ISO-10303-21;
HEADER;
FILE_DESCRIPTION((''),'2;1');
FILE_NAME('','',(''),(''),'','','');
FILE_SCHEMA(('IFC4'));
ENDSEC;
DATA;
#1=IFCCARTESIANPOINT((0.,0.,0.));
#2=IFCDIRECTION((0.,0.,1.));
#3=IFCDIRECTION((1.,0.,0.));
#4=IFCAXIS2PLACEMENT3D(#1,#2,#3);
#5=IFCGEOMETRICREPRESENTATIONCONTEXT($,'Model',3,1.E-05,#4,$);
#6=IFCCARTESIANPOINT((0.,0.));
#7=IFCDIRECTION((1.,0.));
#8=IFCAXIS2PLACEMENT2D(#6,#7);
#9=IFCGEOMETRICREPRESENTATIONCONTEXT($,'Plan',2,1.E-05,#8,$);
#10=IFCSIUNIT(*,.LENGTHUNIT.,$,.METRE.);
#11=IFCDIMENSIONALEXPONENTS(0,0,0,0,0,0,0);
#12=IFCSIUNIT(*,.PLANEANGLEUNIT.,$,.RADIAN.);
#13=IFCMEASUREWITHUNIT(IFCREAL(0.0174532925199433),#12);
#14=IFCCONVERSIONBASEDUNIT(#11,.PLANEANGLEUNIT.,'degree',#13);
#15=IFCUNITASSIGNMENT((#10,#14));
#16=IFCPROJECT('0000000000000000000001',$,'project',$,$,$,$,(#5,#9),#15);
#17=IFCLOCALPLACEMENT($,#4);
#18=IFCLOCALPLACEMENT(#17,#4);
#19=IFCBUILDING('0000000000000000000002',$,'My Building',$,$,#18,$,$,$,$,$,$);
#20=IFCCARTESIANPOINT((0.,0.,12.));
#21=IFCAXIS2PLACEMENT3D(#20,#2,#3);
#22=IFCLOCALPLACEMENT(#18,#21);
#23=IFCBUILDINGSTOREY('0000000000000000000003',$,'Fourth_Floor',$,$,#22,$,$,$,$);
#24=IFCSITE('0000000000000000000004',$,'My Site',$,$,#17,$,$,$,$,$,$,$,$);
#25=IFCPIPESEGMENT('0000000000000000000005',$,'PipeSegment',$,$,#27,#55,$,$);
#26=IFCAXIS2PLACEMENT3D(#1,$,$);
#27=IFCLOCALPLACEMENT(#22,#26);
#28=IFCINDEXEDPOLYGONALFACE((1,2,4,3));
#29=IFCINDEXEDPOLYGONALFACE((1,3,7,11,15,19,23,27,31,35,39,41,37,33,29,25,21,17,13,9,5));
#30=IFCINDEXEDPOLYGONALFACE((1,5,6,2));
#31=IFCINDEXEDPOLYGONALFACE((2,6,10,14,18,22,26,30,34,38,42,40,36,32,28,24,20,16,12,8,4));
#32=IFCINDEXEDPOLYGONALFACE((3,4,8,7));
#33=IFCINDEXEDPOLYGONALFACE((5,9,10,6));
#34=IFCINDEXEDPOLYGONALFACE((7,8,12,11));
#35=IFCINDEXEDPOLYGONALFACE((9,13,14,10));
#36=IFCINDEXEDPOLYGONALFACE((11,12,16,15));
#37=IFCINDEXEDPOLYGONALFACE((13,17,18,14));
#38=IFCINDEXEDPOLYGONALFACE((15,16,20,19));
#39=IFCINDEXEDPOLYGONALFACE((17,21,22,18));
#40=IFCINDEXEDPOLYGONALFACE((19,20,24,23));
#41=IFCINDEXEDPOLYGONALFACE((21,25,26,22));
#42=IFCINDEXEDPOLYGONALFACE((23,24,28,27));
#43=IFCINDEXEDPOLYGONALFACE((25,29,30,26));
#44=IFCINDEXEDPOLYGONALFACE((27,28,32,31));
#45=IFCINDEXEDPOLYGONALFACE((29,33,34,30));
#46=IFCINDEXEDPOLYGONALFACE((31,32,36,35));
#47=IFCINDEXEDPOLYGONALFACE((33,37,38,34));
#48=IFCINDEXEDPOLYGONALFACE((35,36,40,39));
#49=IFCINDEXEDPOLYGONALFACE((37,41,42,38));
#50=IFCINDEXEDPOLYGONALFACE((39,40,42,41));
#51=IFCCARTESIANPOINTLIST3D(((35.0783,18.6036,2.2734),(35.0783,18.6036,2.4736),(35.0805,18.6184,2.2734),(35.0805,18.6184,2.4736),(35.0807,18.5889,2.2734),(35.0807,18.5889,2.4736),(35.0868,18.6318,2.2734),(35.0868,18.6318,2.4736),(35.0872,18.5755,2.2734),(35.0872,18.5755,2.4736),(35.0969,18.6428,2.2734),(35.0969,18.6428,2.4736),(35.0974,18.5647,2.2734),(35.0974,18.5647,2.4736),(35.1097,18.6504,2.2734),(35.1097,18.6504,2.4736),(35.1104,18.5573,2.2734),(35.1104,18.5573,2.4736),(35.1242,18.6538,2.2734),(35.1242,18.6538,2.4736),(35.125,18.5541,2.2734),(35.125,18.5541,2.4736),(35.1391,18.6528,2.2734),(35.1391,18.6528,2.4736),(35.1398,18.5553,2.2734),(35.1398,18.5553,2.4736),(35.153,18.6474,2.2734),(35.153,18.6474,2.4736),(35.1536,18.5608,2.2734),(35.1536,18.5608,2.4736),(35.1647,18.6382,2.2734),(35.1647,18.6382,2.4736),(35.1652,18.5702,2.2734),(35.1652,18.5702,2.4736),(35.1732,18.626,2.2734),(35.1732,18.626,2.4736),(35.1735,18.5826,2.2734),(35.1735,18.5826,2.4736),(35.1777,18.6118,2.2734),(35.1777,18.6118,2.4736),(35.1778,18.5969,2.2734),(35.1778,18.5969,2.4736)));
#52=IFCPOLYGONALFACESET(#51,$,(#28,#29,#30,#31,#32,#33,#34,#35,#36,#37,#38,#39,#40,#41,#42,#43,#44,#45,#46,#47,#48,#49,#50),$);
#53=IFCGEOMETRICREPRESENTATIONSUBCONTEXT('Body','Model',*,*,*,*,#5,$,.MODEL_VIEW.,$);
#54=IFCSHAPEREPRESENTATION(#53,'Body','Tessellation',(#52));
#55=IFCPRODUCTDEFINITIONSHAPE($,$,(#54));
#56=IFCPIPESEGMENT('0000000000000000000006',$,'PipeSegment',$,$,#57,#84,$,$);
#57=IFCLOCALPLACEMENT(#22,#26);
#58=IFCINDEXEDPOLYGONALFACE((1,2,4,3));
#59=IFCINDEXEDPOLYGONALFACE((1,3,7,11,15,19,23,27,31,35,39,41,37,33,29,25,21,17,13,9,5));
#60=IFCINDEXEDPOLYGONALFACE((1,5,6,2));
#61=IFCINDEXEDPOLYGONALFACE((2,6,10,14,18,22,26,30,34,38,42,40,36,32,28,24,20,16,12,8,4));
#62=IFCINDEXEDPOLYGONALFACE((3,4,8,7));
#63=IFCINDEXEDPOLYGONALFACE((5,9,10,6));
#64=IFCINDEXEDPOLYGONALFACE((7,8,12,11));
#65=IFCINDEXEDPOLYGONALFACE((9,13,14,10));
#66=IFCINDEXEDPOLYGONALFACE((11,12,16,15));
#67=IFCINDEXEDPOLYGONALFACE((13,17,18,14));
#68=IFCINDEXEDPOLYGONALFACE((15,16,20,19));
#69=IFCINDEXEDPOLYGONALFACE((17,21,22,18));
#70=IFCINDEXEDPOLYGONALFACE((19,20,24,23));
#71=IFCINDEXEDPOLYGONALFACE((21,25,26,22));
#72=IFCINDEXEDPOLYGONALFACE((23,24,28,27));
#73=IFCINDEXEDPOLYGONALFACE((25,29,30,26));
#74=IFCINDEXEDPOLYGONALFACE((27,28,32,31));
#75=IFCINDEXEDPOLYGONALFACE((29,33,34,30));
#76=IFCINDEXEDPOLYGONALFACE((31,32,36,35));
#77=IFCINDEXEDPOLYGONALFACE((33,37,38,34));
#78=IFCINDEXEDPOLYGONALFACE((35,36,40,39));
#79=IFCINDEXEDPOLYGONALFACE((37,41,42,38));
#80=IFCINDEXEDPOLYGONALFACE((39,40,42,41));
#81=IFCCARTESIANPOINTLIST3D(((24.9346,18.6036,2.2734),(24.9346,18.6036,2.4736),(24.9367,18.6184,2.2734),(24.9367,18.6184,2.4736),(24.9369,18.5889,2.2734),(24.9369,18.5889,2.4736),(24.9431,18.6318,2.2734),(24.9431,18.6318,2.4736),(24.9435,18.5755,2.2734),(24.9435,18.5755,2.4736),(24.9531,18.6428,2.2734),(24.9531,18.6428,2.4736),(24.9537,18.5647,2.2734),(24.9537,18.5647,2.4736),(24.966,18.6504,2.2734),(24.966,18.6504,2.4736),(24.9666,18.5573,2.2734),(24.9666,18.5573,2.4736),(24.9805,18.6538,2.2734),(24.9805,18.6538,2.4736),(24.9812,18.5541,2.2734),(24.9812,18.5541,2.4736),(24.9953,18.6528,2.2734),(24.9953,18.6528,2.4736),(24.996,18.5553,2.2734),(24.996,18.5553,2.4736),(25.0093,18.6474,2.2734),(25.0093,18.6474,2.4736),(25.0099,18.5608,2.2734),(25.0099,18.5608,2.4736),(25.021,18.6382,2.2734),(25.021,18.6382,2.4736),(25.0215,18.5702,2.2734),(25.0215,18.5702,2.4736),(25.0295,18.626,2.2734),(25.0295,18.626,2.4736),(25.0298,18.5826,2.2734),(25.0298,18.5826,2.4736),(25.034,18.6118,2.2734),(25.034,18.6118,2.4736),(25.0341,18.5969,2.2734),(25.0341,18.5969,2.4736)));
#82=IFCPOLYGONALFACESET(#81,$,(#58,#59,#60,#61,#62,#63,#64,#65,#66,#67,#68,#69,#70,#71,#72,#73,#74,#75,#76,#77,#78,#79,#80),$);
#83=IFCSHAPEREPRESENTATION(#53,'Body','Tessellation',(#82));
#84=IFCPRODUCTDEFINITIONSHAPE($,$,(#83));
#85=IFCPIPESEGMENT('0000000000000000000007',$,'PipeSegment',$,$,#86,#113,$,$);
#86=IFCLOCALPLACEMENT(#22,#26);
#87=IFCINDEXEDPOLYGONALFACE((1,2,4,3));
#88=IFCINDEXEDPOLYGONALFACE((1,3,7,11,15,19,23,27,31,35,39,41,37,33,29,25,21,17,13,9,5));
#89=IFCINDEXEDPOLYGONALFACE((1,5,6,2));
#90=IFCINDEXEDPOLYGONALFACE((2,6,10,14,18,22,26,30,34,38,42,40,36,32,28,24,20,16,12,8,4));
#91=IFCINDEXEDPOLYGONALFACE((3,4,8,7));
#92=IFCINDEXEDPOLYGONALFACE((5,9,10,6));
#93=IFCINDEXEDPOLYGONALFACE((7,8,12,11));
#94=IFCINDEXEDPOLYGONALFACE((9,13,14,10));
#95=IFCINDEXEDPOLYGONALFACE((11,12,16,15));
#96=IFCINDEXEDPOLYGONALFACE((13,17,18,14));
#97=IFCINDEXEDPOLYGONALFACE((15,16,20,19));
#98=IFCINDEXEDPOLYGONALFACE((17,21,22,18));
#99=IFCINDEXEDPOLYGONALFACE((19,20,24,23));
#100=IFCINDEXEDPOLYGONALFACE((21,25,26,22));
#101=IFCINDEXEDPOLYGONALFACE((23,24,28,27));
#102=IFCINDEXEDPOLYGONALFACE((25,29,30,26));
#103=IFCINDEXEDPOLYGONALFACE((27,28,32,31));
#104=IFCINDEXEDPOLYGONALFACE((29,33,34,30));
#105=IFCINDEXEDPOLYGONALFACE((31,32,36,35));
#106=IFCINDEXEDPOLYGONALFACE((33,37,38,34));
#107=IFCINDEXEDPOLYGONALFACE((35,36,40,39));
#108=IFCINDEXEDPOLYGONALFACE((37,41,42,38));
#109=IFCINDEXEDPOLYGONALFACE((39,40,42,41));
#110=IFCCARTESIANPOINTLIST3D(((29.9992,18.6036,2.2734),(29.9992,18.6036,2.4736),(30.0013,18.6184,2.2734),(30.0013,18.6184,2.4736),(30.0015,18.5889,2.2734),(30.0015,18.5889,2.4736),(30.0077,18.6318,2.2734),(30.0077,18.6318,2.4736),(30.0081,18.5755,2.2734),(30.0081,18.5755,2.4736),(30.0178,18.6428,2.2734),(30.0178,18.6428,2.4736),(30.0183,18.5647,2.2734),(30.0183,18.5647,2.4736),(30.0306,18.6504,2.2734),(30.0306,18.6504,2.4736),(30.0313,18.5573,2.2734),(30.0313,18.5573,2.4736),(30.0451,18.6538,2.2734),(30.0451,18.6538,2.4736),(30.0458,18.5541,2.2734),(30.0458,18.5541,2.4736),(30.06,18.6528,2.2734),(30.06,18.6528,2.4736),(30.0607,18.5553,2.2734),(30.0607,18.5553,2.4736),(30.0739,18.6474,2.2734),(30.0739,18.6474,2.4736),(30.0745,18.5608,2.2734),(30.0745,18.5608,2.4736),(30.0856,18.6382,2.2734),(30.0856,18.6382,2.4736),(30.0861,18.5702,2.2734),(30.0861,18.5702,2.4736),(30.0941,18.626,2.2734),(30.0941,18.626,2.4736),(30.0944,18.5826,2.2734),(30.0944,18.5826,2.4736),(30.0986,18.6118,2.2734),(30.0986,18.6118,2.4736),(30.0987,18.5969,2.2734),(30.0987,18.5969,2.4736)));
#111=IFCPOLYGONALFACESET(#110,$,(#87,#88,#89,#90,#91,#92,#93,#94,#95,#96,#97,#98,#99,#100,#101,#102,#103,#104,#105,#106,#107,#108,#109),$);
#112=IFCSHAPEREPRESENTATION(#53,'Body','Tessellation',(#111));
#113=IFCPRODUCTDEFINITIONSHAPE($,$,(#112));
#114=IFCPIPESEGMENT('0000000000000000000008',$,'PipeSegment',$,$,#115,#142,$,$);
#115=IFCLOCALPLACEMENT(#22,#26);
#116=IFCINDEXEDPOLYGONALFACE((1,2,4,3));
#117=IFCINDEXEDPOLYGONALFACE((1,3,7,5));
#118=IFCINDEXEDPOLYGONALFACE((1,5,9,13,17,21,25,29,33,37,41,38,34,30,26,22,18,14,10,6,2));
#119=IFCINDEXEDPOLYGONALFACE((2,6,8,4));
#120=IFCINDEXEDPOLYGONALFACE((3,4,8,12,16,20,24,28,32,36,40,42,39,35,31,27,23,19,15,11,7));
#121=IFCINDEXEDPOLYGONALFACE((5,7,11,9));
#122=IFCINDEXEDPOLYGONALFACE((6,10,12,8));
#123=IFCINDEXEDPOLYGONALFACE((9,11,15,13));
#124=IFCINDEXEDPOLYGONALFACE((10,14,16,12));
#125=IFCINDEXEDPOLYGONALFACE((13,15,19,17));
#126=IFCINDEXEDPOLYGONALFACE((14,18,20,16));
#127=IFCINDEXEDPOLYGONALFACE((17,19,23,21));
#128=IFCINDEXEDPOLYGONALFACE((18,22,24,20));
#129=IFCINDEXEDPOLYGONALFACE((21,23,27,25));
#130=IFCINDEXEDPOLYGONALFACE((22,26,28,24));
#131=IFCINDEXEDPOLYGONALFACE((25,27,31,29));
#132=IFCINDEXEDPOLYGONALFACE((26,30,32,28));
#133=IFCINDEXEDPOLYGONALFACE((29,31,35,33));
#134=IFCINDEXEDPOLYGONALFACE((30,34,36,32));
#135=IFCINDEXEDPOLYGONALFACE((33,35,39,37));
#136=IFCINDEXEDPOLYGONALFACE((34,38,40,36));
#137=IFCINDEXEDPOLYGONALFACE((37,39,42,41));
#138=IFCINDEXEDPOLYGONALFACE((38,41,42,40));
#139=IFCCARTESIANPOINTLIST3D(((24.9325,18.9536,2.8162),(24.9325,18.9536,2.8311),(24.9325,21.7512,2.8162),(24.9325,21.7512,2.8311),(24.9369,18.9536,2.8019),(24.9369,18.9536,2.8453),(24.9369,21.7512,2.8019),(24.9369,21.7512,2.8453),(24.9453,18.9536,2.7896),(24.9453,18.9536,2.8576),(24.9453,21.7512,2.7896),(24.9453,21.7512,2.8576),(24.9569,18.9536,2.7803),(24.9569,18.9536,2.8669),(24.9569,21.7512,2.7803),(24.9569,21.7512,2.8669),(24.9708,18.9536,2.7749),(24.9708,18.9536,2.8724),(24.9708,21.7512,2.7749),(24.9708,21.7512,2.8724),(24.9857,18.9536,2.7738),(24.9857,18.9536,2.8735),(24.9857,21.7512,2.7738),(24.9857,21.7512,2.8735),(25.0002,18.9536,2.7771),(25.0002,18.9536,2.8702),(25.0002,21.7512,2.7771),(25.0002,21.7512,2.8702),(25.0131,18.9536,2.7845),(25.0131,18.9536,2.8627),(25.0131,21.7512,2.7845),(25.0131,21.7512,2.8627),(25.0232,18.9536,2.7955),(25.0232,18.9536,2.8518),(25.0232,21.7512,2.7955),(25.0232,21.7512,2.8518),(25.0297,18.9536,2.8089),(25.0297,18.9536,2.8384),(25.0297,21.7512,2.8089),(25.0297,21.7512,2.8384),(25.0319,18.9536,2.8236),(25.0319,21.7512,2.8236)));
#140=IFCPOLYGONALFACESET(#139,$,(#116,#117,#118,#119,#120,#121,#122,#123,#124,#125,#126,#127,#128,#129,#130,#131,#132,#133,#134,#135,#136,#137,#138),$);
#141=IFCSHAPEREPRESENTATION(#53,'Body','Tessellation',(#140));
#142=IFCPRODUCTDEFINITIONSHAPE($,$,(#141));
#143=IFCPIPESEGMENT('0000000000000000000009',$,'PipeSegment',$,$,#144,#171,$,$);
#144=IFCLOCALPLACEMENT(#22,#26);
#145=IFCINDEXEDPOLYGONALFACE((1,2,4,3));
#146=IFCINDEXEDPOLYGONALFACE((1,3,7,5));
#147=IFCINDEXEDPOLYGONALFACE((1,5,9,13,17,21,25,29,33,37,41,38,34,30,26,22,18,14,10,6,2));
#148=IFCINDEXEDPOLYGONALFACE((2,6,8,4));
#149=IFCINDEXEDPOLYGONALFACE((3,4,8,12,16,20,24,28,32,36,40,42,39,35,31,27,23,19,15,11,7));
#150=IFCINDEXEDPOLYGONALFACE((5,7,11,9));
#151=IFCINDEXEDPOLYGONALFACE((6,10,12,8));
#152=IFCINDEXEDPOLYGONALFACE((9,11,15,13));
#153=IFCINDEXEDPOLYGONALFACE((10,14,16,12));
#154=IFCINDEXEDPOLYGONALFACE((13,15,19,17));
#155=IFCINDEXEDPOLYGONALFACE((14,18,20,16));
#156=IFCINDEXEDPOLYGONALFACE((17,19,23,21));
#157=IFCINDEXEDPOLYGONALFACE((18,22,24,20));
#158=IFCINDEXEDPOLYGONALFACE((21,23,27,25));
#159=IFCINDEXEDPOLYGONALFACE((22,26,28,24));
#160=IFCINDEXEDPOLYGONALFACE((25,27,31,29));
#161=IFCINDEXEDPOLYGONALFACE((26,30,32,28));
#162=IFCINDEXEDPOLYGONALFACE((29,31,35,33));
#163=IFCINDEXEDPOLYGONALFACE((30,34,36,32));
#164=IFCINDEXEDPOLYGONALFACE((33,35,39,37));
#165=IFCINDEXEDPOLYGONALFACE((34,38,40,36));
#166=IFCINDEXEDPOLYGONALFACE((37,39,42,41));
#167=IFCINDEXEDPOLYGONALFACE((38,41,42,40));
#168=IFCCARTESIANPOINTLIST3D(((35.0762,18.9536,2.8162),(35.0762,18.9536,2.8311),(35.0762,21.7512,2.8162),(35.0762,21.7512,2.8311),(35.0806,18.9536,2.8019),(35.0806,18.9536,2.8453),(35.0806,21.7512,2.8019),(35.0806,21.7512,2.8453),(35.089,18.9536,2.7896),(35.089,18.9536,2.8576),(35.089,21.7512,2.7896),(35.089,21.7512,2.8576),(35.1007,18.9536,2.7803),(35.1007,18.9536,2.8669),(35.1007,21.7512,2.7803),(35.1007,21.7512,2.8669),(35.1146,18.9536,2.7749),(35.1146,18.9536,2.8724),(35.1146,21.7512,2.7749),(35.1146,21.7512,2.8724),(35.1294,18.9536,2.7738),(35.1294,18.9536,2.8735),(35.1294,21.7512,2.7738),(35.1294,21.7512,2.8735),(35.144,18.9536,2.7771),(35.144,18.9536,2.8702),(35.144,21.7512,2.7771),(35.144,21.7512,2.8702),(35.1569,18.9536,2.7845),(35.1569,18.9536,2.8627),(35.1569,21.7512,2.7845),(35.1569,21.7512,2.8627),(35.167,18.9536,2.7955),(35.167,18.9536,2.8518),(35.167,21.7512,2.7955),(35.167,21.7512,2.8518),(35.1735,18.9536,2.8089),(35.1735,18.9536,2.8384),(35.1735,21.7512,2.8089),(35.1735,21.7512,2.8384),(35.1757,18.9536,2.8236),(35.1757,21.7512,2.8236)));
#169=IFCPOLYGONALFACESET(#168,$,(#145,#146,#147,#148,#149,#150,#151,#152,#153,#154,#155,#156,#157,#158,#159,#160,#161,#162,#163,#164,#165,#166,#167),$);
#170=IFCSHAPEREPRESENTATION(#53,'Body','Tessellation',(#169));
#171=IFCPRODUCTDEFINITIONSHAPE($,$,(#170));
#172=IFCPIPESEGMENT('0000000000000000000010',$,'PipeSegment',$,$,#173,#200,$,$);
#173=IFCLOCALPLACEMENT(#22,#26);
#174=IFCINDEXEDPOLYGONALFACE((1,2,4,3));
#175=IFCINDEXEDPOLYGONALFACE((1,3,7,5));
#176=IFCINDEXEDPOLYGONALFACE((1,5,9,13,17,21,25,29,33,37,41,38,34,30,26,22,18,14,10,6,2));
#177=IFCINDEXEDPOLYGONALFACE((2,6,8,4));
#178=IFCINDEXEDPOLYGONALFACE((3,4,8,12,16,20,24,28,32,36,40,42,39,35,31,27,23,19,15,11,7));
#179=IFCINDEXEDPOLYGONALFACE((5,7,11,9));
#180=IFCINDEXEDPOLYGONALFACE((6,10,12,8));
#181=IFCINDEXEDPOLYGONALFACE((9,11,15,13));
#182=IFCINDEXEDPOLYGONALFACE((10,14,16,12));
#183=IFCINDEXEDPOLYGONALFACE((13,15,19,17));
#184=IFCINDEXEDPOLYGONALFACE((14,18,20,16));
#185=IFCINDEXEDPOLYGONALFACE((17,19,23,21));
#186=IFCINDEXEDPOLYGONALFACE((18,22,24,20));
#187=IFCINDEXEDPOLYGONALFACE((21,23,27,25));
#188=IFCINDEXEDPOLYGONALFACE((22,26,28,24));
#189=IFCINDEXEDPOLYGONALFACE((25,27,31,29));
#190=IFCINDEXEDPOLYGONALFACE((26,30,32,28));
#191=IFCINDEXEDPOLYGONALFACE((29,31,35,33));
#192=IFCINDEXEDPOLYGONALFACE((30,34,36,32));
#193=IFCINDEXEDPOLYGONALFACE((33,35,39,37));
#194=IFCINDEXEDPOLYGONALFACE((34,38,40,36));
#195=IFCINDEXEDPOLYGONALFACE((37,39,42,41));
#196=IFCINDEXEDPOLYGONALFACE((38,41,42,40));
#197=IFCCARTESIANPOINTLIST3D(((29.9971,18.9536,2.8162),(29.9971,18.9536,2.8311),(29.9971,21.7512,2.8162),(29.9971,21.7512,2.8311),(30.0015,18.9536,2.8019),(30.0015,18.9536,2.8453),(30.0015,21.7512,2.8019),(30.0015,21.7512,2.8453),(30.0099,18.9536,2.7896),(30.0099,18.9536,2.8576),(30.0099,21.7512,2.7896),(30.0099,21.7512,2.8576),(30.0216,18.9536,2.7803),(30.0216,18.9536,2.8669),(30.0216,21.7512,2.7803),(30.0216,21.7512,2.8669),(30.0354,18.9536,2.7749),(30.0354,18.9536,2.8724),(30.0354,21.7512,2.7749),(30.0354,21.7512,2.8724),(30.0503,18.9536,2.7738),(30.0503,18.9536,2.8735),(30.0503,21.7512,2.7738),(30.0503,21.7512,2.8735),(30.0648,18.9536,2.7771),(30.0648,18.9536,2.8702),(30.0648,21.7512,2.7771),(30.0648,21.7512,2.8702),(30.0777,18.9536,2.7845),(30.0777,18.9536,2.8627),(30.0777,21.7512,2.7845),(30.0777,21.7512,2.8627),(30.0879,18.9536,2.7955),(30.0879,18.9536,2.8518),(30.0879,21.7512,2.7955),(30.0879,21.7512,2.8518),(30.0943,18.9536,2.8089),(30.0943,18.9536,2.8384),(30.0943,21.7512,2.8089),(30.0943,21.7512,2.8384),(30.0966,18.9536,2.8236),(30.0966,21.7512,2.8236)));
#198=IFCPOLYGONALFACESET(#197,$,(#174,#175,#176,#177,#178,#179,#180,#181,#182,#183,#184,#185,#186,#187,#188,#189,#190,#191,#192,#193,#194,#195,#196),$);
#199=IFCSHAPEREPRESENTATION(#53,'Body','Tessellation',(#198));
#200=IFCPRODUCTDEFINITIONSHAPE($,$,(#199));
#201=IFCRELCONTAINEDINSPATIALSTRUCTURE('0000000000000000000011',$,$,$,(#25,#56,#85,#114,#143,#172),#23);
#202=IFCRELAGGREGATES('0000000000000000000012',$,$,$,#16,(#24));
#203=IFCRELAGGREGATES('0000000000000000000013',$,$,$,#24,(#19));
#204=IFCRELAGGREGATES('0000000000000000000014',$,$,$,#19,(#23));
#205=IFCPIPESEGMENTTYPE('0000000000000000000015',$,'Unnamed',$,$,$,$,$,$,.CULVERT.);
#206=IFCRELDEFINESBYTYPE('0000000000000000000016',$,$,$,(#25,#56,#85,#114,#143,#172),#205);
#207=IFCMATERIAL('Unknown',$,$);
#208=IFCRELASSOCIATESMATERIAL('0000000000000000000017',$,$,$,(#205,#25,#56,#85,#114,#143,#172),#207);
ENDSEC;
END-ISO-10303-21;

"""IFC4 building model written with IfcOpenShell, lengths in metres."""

from ifc_helpers import new_model, entity, si_unit, converted_unit, frame, origin_with_axes, origin_2d_with_axis, place, context, subcontext, project, spatial, circle, extrude, material, material_profile, profile_set, profile_usage, type_object, element, save


model = new_model("IFC4")

# Units and contexts
model_context = context("Model", 3, precision=1e-05, world=origin_with_axes())
plan_context = context("Plan", 2, precision=1e-05, world=origin_2d_with_axis())
body_context_1 = subcontext(model_context, "Body", "Model", "MODEL_VIEW")
ifc_project = project(units=[si_unit("LENGTHUNIT", "METRE"), converted_unit("PLANEANGLEUNIT", "degree", entity("IfcReal", 0.0174532925199433), si_unit("PLANEANGLEUNIT", "RADIAN"), dimensions=[0, 0, 0, 0, 0, 0, 0])], contexts=[model_context, plan_context])

# Site, building, storey
site_placement = place(None, origin_with_axes())
site = spatial("IfcSite", under=ifc_project, at=site_placement, Name="My Site")
building_placement = place(site_placement, origin_with_axes())
building = spatial("IfcBuilding", under=site, at=building_placement, Name="My Building")
storey_placement = place(building_placement, frame((0.0, 0.0, 12.0), z_axis=(0.0, 0.0, 1.0), x_axis=(1.0, 0.0, 0.0)))
storey = spatial("IfcBuildingStorey", under=building, at=storey_placement, Name="Fourth_Floor")

# Shared definitions
ifc_material = material(Name="Unknown")

# Pipe segments
ifc_material_profile_1 = material_profile(ifc_material, circle(Radius=0.05))
ifc_profile_set_1 = profile_set([ifc_material_profile_1])
ifc_profile_usage_1 = profile_usage(ifc_profile_set_1, cardinal=5)
pipe_segment_type = type_object("IfcPipeSegmentType", Name="Unnamed", PredefinedType="CULVERT", material=ifc_profile_set_1)
pipe_segment_1_placement = place(storey_placement, frame((35.1283, 18.604, 2.4736), z_axis=(-0.000001, 0.0, -1.0), x_axis=(-0.999975, -0.007084, 0.000001)))
element("IfcPipeSegment", 1, at=pipe_segment_1_placement, inside=storey, type_object=pipe_segment_type, material=ifc_profile_usage_1, Name="PipeSegment", context=body_context_1, shape_type="SweptSolid", body=[
    extrude(circle(Radius=0.05), origin_with_axes(), (0.0, 0.0, 1.0), 0.2002),
])
ifc_profile_usage_2 = profile_usage(ifc_profile_set_1, cardinal=5)
pipe_segment_2_placement = place(storey_placement, frame((24.9846, 18.604, 2.4736), z_axis=(-0.000001, 0.0, -1.0), x_axis=(-0.999975, -0.007084, 0.000001)))
element("IfcPipeSegment", 2, at=pipe_segment_2_placement, inside=storey, type_object=pipe_segment_type, material=ifc_profile_usage_2, Name="PipeSegment", context=body_context_1, shape_type="SweptSolid", body=[
    extrude(circle(Radius=0.05), origin_with_axes(), (0.0, 0.0, 1.0), 0.2002),
])
ifc_profile_usage_3 = profile_usage(ifc_profile_set_1, cardinal=5)
pipe_segment_3_placement = place(storey_placement, frame((30.0492, 18.604, 2.4736), z_axis=(-0.000001, 0.0, -1.0), x_axis=(-0.999975, -0.007084, 0.000001)))
element("IfcPipeSegment", 3, at=pipe_segment_3_placement, inside=storey, type_object=pipe_segment_type, material=ifc_profile_usage_3, Name="PipeSegment", context=body_context_1, shape_type="SweptSolid", body=[
    extrude(circle(Radius=0.05), origin_with_axes(), (0.0, 0.0, 1.0), 0.2002),
])
ifc_profile_usage_4 = profile_usage(ifc_profile_set_1, cardinal=5)
pipe_segment_4_placement = place(storey_placement, frame((24.9819, 21.7512, 2.8236), z_axis=(0.0, -1.0, 0.0), x_axis=(1.0, 0.0, 0.0)))
element("IfcPipeSegment", 4, at=pipe_segment_4_placement, inside=storey, type_object=pipe_segment_type, material=ifc_profile_usage_4, Name="PipeSegment", context=body_context_1, shape_type="SweptSolid", body=[
    extrude(circle(Radius=0.05), origin_with_axes(), (0.0, 0.0, 1.0), 2.7976),
])
ifc_profile_usage_5 = profile_usage(ifc_profile_set_1, cardinal=5)
pipe_segment_5_placement = place(storey_placement, frame((35.1257, 21.7512, 2.8236), z_axis=(0.0, -1.0, 0.0), x_axis=(1.0, 0.0, 0.0)))
element("IfcPipeSegment", 5, at=pipe_segment_5_placement, inside=storey, type_object=pipe_segment_type, material=ifc_profile_usage_5, Name="PipeSegment", context=body_context_1, shape_type="SweptSolid", body=[
    extrude(circle(Radius=0.05), origin_with_axes(), (0.0, 0.0, 1.0), 2.7976),
])
ifc_profile_usage_6 = profile_usage(ifc_profile_set_1, cardinal=5)
pipe_segment_6_placement = place(storey_placement, frame((30.0466, 21.7512, 2.8236), z_axis=(0.0, -1.0, 0.0), x_axis=(1.0, 0.0, 0.0)))
element("IfcPipeSegment", 6, at=pipe_segment_6_placement, inside=storey, type_object=pipe_segment_type, material=ifc_profile_usage_6, Name="PipeSegment", context=body_context_1, shape_type="SweptSolid", body=[
    extrude(circle(Radius=0.05), origin_with_axes(), (0.0, 0.0, 1.0), 2.7976),
])

save(model, "model.ifc")
